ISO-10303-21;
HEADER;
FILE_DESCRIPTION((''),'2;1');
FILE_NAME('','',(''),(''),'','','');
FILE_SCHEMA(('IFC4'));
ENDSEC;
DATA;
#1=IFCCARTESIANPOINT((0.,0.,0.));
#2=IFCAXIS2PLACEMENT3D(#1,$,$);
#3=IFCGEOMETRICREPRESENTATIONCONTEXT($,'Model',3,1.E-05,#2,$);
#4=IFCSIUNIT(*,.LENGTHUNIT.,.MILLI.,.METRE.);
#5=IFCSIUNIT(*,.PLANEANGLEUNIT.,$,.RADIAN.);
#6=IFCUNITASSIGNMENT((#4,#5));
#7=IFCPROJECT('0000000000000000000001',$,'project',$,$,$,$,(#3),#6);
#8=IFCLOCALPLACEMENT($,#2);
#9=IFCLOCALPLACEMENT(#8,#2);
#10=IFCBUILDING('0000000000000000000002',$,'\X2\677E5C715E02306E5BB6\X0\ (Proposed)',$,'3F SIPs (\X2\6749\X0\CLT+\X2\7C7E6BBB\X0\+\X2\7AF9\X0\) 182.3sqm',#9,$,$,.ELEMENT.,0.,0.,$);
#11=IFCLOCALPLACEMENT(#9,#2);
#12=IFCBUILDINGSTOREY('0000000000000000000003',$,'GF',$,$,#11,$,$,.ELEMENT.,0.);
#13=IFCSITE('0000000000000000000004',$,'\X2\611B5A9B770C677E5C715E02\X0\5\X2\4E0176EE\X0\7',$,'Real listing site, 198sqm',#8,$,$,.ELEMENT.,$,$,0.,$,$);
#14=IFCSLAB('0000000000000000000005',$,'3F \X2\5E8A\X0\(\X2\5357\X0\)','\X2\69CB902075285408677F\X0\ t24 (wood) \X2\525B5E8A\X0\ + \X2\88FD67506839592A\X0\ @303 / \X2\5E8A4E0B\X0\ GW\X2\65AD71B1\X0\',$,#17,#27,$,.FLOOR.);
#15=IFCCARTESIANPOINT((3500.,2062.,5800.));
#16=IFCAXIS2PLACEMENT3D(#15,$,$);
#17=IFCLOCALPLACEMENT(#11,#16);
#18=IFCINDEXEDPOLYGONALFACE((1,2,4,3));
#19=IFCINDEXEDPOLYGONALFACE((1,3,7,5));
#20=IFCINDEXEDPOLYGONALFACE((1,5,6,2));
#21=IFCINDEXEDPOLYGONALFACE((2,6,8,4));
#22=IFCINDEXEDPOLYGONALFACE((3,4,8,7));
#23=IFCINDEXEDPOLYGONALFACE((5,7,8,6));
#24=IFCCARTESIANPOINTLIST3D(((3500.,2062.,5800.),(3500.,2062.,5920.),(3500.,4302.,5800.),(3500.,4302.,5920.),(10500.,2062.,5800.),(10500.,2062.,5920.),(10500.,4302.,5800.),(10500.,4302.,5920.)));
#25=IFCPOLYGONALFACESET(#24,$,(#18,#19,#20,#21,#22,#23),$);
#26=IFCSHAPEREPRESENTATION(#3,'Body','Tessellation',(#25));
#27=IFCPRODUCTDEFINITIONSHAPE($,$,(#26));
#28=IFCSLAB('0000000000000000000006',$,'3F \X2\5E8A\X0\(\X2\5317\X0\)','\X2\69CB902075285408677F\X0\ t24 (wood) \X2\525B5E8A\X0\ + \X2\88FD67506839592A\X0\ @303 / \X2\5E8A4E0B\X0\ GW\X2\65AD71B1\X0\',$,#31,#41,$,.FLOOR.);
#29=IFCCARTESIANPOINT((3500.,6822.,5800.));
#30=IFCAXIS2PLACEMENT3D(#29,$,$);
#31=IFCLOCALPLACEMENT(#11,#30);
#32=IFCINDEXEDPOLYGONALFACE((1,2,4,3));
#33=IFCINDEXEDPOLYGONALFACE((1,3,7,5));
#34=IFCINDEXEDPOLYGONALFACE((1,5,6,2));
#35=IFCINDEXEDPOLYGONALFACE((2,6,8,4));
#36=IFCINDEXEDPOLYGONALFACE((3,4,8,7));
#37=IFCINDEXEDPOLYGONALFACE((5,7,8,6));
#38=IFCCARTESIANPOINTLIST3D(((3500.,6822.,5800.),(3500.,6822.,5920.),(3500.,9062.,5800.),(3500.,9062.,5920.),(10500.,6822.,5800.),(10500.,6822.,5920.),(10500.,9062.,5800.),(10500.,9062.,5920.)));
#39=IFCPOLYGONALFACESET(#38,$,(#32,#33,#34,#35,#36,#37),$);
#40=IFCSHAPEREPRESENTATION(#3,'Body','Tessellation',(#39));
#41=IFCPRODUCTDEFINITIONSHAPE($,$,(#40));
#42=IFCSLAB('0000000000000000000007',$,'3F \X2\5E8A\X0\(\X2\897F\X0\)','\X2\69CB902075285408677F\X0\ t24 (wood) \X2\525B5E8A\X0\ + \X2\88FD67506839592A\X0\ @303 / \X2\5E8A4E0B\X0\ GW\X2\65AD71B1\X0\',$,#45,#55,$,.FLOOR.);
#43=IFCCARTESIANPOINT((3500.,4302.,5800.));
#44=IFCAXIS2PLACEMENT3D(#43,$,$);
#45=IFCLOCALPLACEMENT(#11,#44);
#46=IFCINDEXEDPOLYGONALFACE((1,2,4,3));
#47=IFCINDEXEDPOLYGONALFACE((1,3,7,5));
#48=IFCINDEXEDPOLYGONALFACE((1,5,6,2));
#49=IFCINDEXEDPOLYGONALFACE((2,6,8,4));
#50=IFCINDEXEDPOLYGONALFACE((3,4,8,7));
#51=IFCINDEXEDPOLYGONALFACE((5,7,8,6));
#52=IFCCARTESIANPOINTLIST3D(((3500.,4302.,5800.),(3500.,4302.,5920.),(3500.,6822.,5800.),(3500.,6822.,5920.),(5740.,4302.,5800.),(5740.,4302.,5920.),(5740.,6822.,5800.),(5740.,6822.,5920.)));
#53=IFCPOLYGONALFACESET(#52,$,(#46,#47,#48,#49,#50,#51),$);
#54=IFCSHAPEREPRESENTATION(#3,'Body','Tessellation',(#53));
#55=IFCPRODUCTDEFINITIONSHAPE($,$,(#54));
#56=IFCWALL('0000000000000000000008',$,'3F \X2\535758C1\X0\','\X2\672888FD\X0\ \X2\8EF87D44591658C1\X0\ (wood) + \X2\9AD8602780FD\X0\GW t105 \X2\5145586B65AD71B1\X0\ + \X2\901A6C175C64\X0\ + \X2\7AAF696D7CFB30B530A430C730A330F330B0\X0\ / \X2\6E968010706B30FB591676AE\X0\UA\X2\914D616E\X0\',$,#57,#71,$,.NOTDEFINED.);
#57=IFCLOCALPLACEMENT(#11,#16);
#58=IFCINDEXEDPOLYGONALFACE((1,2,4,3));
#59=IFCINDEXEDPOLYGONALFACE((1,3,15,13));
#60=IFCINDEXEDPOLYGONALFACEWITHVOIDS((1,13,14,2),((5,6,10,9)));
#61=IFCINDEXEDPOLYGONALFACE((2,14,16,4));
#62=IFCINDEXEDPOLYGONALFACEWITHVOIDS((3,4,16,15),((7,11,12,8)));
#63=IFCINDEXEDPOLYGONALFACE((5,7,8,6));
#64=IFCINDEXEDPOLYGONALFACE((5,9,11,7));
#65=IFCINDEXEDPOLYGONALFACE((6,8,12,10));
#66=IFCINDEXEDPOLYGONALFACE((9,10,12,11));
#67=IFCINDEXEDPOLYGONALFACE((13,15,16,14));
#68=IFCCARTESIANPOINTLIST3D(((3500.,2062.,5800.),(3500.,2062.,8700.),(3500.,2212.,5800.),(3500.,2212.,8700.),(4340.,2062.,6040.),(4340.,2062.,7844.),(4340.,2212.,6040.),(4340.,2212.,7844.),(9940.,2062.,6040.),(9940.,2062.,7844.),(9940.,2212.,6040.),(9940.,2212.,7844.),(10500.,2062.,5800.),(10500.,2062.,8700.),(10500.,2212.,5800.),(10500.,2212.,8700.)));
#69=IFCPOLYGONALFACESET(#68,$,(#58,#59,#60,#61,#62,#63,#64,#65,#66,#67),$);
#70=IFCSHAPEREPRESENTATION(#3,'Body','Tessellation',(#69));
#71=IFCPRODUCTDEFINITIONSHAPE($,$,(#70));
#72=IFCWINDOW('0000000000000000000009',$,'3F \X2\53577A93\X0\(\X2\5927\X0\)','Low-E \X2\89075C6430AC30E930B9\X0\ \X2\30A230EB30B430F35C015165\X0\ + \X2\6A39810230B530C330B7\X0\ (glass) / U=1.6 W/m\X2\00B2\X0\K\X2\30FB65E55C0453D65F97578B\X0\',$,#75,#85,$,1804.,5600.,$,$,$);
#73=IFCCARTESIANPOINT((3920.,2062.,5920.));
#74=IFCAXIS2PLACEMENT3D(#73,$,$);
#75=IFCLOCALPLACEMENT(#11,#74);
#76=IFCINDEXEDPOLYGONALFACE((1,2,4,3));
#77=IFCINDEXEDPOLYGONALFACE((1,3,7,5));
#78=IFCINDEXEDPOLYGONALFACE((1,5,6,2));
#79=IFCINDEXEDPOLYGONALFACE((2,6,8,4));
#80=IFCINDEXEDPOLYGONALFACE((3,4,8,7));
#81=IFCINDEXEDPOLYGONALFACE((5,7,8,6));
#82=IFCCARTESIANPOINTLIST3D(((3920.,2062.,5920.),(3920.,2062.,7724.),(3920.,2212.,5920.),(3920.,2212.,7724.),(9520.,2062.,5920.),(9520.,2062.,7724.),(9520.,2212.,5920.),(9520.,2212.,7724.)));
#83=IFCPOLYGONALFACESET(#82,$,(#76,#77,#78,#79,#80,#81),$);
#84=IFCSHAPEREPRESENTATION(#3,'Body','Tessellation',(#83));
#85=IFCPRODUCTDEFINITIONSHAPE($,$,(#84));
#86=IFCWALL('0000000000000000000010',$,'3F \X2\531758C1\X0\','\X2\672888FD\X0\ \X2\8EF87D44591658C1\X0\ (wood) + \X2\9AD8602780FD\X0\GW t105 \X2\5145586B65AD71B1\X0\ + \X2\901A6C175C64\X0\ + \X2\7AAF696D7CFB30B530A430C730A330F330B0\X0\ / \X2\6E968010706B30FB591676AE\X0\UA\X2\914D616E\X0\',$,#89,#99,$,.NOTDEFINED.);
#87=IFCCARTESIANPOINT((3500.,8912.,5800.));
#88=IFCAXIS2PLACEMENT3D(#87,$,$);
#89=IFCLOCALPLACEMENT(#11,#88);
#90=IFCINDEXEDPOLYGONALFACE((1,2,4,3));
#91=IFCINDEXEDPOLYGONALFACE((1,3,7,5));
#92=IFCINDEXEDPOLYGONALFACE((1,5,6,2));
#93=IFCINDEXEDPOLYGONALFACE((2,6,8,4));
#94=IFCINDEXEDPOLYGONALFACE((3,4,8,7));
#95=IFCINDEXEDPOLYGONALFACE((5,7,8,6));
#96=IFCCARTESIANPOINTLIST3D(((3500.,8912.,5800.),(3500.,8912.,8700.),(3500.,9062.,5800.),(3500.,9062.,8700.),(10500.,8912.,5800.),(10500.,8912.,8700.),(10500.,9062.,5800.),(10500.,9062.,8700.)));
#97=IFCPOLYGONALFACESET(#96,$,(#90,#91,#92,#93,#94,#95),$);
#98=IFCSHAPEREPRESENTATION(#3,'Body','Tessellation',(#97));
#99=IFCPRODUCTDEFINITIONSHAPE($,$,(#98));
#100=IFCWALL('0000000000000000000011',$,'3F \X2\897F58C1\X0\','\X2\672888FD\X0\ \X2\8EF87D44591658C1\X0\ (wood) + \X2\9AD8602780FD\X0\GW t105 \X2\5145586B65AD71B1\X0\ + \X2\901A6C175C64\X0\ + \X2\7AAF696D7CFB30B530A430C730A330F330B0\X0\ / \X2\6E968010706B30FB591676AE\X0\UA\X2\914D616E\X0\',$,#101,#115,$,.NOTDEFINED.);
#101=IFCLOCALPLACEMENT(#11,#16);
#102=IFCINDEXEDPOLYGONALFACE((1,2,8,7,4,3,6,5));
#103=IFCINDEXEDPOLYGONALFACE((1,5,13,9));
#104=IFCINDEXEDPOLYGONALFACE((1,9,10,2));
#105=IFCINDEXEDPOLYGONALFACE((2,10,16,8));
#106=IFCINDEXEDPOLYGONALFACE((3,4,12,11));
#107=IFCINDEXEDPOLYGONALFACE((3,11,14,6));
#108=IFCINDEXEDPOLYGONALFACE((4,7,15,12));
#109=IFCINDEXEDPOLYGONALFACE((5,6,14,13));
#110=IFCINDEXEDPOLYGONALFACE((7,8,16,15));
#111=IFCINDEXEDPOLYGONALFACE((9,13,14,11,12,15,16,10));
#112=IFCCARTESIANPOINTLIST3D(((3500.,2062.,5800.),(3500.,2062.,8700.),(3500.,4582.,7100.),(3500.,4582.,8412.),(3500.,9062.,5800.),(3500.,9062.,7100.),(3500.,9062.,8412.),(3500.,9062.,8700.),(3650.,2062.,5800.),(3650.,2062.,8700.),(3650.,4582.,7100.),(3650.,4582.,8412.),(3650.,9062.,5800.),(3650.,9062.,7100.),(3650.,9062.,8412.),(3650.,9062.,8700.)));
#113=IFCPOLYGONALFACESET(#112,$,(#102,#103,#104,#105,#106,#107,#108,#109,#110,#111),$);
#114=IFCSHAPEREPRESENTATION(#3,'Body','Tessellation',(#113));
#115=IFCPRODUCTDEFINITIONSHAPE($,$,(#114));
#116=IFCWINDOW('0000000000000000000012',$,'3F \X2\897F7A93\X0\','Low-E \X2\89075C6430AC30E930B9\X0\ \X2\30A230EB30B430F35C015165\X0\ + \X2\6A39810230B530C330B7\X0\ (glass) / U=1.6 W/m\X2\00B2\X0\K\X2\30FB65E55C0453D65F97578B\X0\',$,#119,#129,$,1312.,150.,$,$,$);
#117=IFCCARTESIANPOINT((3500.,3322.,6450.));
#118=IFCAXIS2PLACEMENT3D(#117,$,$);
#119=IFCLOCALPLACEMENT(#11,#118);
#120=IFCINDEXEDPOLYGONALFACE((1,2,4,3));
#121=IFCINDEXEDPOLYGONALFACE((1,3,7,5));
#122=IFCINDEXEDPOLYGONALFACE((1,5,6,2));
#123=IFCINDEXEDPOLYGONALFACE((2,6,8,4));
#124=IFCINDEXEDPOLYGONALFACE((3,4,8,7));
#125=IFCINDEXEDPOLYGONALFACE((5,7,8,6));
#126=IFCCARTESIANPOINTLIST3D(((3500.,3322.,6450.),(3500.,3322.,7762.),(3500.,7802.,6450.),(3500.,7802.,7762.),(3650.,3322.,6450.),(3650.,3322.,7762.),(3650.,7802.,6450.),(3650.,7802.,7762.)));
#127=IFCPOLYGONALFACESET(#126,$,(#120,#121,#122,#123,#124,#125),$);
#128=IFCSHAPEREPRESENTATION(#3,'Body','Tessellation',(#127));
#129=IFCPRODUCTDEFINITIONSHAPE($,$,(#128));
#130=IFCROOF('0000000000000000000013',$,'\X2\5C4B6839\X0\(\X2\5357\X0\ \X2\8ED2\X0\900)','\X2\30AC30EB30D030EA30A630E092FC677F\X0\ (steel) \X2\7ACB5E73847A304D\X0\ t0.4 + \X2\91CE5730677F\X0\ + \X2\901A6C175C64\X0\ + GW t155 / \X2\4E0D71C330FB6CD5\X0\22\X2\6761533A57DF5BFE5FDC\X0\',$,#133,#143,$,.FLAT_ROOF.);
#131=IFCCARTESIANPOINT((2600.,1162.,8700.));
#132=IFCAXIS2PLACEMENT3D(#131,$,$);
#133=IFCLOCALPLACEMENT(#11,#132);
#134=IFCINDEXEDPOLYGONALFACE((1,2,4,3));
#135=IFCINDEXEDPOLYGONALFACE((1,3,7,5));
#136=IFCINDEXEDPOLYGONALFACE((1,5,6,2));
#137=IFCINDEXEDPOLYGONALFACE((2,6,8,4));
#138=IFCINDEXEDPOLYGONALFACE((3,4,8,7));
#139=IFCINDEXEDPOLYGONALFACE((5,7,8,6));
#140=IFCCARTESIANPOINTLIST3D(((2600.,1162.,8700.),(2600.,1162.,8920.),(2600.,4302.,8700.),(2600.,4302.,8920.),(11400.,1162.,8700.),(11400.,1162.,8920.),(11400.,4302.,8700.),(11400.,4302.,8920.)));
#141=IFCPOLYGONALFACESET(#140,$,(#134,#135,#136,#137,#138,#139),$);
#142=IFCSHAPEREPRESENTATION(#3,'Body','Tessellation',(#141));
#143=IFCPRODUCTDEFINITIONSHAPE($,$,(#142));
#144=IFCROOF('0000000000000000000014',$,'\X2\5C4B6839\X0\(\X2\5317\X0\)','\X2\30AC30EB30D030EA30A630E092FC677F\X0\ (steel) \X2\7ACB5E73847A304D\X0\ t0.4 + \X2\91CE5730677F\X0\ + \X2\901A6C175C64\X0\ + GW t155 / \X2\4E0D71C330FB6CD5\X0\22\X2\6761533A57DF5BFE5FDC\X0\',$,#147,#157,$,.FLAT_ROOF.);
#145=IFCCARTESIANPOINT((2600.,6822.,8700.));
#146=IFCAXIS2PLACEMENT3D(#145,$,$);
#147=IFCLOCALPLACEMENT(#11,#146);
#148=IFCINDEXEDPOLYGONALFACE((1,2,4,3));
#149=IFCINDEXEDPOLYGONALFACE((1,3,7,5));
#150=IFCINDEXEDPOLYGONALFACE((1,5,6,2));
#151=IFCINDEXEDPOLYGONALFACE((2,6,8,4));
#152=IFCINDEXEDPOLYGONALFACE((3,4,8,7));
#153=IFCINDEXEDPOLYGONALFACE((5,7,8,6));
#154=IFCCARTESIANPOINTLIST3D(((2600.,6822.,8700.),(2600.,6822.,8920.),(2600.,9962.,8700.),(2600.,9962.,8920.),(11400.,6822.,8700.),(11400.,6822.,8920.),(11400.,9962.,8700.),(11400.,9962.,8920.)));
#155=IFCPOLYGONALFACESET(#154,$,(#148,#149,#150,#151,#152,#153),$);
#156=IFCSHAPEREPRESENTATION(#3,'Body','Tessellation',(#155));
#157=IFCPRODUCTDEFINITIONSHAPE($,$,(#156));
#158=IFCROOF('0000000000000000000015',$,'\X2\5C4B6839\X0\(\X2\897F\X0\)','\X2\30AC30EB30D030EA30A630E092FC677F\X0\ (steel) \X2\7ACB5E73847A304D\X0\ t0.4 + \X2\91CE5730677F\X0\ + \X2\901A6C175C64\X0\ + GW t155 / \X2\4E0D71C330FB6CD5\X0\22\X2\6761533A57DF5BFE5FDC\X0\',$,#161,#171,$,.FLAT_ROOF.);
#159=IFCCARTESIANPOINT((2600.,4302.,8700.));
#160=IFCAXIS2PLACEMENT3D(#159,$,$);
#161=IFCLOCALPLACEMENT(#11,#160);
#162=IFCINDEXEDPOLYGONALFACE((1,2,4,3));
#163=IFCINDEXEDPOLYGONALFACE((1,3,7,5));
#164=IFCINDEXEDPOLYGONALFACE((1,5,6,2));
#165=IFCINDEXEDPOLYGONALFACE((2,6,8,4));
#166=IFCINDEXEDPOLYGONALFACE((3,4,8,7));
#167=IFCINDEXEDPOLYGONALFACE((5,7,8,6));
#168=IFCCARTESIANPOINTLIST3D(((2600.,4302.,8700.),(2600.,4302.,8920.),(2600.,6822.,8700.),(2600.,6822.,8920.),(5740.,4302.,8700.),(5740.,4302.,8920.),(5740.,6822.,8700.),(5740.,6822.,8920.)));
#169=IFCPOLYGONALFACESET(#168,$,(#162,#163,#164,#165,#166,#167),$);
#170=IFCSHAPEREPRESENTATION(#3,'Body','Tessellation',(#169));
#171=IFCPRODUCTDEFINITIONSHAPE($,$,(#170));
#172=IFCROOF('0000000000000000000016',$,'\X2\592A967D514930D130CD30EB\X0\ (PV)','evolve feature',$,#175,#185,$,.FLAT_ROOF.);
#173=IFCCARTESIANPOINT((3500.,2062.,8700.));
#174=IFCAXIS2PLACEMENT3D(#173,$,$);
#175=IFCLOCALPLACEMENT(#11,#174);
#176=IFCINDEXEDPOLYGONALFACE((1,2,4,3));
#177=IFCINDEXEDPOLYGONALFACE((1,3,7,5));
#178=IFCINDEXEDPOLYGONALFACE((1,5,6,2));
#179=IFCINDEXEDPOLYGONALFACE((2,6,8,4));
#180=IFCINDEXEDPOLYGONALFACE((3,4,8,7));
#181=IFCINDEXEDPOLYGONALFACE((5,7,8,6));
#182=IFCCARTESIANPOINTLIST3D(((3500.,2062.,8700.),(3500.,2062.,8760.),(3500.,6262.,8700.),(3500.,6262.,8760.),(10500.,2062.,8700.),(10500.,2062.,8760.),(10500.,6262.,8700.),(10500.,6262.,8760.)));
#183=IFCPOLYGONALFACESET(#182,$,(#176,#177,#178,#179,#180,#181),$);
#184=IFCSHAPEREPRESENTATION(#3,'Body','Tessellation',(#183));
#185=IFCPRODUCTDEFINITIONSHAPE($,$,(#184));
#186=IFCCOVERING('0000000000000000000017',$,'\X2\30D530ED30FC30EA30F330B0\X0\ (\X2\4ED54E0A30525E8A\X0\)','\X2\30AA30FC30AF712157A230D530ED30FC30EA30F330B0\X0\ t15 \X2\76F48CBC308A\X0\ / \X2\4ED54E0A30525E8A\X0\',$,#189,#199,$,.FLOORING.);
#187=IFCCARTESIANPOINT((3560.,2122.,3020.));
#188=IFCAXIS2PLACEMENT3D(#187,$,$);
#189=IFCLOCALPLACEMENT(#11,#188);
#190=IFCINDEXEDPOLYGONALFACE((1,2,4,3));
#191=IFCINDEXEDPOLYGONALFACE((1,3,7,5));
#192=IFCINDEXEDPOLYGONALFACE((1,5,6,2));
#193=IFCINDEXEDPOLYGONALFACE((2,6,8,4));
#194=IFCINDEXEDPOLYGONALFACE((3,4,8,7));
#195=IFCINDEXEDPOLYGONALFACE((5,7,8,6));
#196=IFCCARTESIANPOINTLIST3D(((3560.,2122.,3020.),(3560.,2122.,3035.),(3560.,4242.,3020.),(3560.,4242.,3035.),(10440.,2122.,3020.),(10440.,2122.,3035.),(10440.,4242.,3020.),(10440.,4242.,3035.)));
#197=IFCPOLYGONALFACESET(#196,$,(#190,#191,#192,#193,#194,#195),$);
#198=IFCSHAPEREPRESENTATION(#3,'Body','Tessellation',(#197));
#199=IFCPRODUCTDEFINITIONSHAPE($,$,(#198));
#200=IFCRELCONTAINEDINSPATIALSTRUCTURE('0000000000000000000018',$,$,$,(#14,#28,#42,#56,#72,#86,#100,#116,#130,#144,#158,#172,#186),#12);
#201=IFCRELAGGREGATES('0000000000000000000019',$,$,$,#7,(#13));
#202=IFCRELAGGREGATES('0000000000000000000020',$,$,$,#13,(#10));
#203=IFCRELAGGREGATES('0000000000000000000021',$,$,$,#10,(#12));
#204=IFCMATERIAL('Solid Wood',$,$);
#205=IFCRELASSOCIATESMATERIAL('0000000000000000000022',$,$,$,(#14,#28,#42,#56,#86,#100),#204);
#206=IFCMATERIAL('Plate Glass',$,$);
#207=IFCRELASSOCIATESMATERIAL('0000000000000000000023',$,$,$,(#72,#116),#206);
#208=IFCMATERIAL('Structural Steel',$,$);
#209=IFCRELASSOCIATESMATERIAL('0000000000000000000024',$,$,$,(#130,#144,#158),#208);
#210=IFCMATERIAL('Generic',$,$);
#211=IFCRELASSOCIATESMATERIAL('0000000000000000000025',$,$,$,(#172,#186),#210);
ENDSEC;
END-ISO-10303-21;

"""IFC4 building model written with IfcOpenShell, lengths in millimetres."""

from ifc_helpers import new_model, si_unit, frame, frame_2d, origin, place, context, project, spatial, rectangle, extrude, material, element, fill, save


model = new_model("IFC4")

# Units and contexts
model_context = context("Model", 3, precision=1e-05, world=origin())
ifc_project = project(units=[si_unit("LENGTHUNIT", "METRE", prefix="MILLI"), si_unit("PLANEANGLEUNIT", "RADIAN")], contexts=[model_context])

# Site, building, storey
site_placement = place(None, origin())
site = spatial("IfcSite", under=ifc_project, at=site_placement, Name="愛媛県松山市5丁目7", ObjectType="Real listing site, 198sqm", CompositionType="ELEMENT", RefElevation=0.0)
building_placement = place(site_placement, origin())
building = spatial("IfcBuilding", under=site, at=building_placement, Name="松山市の家 (Proposed)", ObjectType="3F SIPs (杉CLT+籾殻+竹) 182.3sqm", CompositionType="ELEMENT", ElevationOfRefHeight=0.0, ElevationOfTerrain=0.0)
storey_placement = place(building_placement, origin())
storey = spatial("IfcBuildingStorey", under=building, at=storey_placement, Name="GF", CompositionType="ELEMENT", Elevation=0.0)

# Slabs
ifc_material_1 = material(Name="Solid Wood")
slab_1_placement = place(storey_placement, frame((3500.0, 2062.0, 5800.0)))
element("IfcSlab", 1, at=slab_1_placement, inside=storey, material=ifc_material_1, Name="3F 床(南)", Description="構造用合板 t24 (wood) 剛床 + 製材根太 @303 / 床下 GW断熱", PredefinedType="FLOOR", context=model_context, shape_type="SweptSolid", body=[
    extrude(rectangle(XDim=7000.0, YDim=2240.0, at=frame_2d((3500.0, 1120.0))), frame((3500.0, 2062.0, 5800.0)), (0.0, 0.0, 1.0), 120.0),
])
slab_2_placement = place(storey_placement, frame((3500.0, 6822.0, 5800.0)))
element("IfcSlab", 2, at=slab_2_placement, inside=storey, material=ifc_material_1, Name="3F 床(北)", Description="構造用合板 t24 (wood) 剛床 + 製材根太 @303 / 床下 GW断熱", PredefinedType="FLOOR", context=model_context, shape_type="SweptSolid", body=[
    extrude(rectangle(XDim=7000.0, YDim=2240.0, at=frame_2d((3500.0, 1120.0))), frame((3500.0, 6822.0, 5800.0)), (0.0, 0.0, 1.0), 120.0),
])
slab_3_placement = place(storey_placement, frame((3500.0, 4302.0, 5800.0)))
element("IfcSlab", 3, at=slab_3_placement, inside=storey, material=ifc_material_1, Name="3F 床(西)", Description="構造用合板 t24 (wood) 剛床 + 製材根太 @303 / 床下 GW断熱", PredefinedType="FLOOR", context=model_context, shape_type="SweptSolid", body=[
    extrude(rectangle(XDim=2240.0, YDim=2520.0, at=frame_2d((1120.0, 1260.0))), frame((3500.0, 4302.0, 5800.0)), (0.0, 0.0, 1.0), 120.0),
])

# Wall, opening, window
wall_1_placement = place(storey_placement, frame((3500.0, 2062.0, 5800.0)))
wall_1 = element("IfcWall", 4, at=wall_1_placement, inside=storey, material=ifc_material_1, Name="3F 南壁", Description="木製 軸組外壁 (wood) + 高性能GW t105 充填断熱 + 通気層 + 窯業系サイディング / 準耐火・外皮UA配慮", PredefinedType="NOTDEFINED", context=model_context, shape_type="SweptSolid", body=[
    extrude(rectangle(XDim=7000.0, YDim=150.0, at=frame_2d((3500.0, 75.0))), frame((3500.0, 2062.0, 5800.0)), (0.0, 0.0, 1.0), 2900.0),
])
opening_1_placement = place(storey_placement, frame((3920.0, 2062.0, 5920.0)))
opening_1 = element("IfcOpeningElement", 5, at=opening_1_placement, cuts=wall_1, PredefinedType="NOTDEFINED", context=model_context, shape_type="SweptSolid", body=[
    extrude(rectangle(XDim=5600.0, YDim=150.0, at=frame_2d((2800.0, 75.0))), frame((3920.0, 2062.0, 5920.0)), (0.0, 0.0, 1.0), 1804.0),
])
ifc_material_2 = material(Name="Plate Glass")
window_1_placement = place(storey_placement, frame((3920.0, 2062.0, 5920.0)))
window_1 = element("IfcWindow", 6, at=window_1_placement, inside=storey, material=ifc_material_2, Name="3F 南窓(大)", Description="Low-E 複層ガラス アルゴン封入 + 樹脂サッシ (glass) / U=1.6 W/m²K・日射取得型", OverallHeight=1804.0, OverallWidth=5600.0, context=model_context, shape_type="SweptSolid", body=[
    extrude(rectangle(XDim=5600.0, YDim=150.0, at=frame_2d((2800.0, 75.0))), frame((3920.0, 2062.0, 5920.0)), (0.0, 0.0, 1.0), 1804.0),
])
fill(opening_1, window_1)

# Wall
wall_2_placement = place(storey_placement, frame((3500.0, 8912.0, 5800.0)))
element("IfcWall", 7, at=wall_2_placement, inside=storey, material=ifc_material_1, Name="3F 北壁", Description="木製 軸組外壁 (wood) + 高性能GW t105 充填断熱 + 通気層 + 窯業系サイディング / 準耐火・外皮UA配慮", PredefinedType="NOTDEFINED", context=model_context, shape_type="SweptSolid", body=[
    extrude(rectangle(XDim=7000.0, YDim=150.0, at=frame_2d((3500.0, 75.0))), frame((3500.0, 8912.0, 5800.0)), (0.0, 0.0, 1.0), 2900.0),
])

# Wall, opening, window
wall_3_placement = place(storey_placement, frame((3500.0, 2062.0, 5800.0)))
wall_3 = element("IfcWall", 8, at=wall_3_placement, inside=storey, material=ifc_material_1, Name="3F 西壁", Description="木製 軸組外壁 (wood) + 高性能GW t105 充填断熱 + 通気層 + 窯業系サイディング / 準耐火・外皮UA配慮", PredefinedType="NOTDEFINED", context=model_context, shape_type="SweptSolid", body=[
    extrude(rectangle(XDim=150.0, YDim=7000.0, at=frame_2d((75.0, 3500.0))), frame((3500.0, 2062.0, 5800.0)), (0.0, 0.0, 1.0), 2900.0),
])
opening_2_placement = place(storey_placement, frame((3500.0, 3322.0, 6450.0)))
opening_2 = element("IfcOpeningElement", 9, at=opening_2_placement, cuts=wall_3, PredefinedType="NOTDEFINED", context=model_context, shape_type="SweptSolid", body=[
    extrude(rectangle(XDim=150.0, YDim=4480.0, at=frame_2d((75.0, 2240.0))), frame((3500.0, 3322.0, 6450.0)), (0.0, 0.0, 1.0), 1312.0),
])
window_2_placement = place(storey_placement, frame((3500.0, 3322.0, 6450.0)))
window_2 = element("IfcWindow", 10, at=window_2_placement, inside=storey, material=ifc_material_2, Name="3F 西窓", Description="Low-E 複層ガラス アルゴン封入 + 樹脂サッシ (glass) / U=1.6 W/m²K・日射取得型", OverallHeight=1312.0, OverallWidth=150.0, context=model_context, shape_type="SweptSolid", body=[
    extrude(rectangle(XDim=150.0, YDim=4480.0, at=frame_2d((75.0, 2240.0))), frame((3500.0, 3322.0, 6450.0)), (0.0, 0.0, 1.0), 1312.0),
])
fill(opening_2, window_2)

# Roofs
ifc_material_3 = material(Name="Structural Steel")
roof_1_placement = place(storey_placement, frame((2600.0, 1162.0, 8700.0)))
element("IfcRoof", 11, at=roof_1_placement, inside=storey, material=ifc_material_3, Name="屋根(南 軒900)", Description="ガルバリウム鋼板 (steel) 立平葺き t0.4 + 野地板 + 通気層 + GW t155 / 不燃・法22条区域対応", PredefinedType="FLAT_ROOF", context=model_context, shape_type="SweptSolid", body=[
    extrude(rectangle(XDim=8800.0, YDim=3140.0, at=frame_2d((4400.0, 1570.0))), frame((2600.0, 1162.0, 8700.0)), (0.0, 0.0, 1.0), 220.0),
])
roof_2_placement = place(storey_placement, frame((2600.0, 6822.0, 8700.0)))
element("IfcRoof", 12, at=roof_2_placement, inside=storey, material=ifc_material_3, Name="屋根(北)", Description="ガルバリウム鋼板 (steel) 立平葺き t0.4 + 野地板 + 通気層 + GW t155 / 不燃・法22条区域対応", PredefinedType="FLAT_ROOF", context=model_context, shape_type="SweptSolid", body=[
    extrude(rectangle(XDim=8800.0, YDim=3140.0, at=frame_2d((4400.0, 1570.0))), frame((2600.0, 6822.0, 8700.0)), (0.0, 0.0, 1.0), 220.0),
])
roof_3_placement = place(storey_placement, frame((2600.0, 4302.0, 8700.0)))
element("IfcRoof", 13, at=roof_3_placement, inside=storey, material=ifc_material_3, Name="屋根(西)", Description="ガルバリウム鋼板 (steel) 立平葺き t0.4 + 野地板 + 通気層 + GW t155 / 不燃・法22条区域対応", PredefinedType="FLAT_ROOF", context=model_context, shape_type="SweptSolid", body=[
    extrude(rectangle(XDim=3140.0, YDim=2520.0, at=frame_2d((1570.0, 1260.0))), frame((2600.0, 4302.0, 8700.0)), (0.0, 0.0, 1.0), 220.0),
])
ifc_material_4 = material(Name="Generic")
roof_4_placement = place(storey_placement, frame((3500.0, 2062.0, 8700.0)))
element("IfcRoof", 14, at=roof_4_placement, inside=storey, material=ifc_material_4, Name="太陽光パネル (PV)", Description="evolve feature", PredefinedType="FLAT_ROOF", context=model_context, shape_type="SweptSolid", body=[
    extrude(rectangle(XDim=7000.0, YDim=4200.0, at=frame_2d((3500.0, 2100.0))), frame((3500.0, 2062.0, 8700.0)), (0.0, 0.0, 1.0), 60.0),
])

# Covering
covering_1_placement = place(storey_placement, frame((3560.0, 2122.0, 3020.0)))
element("IfcCovering", 15, at=covering_1_placement, inside=storey, material=ifc_material_4, Name="フローリング (仕上げ床)", Description="オーク無垢フローリング t15 直貼り / 仕上げ床", PredefinedType="FLOORING", context=model_context, shape_type="SweptSolid", body=[
    extrude(rectangle(XDim=6880.0, YDim=2120.0, at=frame_2d((3440.0, 1060.0))), frame((3560.0, 2122.0, 3020.0)), (0.0, 0.0, 1.0), 15.0),
])

save(model, "model.ifc")
